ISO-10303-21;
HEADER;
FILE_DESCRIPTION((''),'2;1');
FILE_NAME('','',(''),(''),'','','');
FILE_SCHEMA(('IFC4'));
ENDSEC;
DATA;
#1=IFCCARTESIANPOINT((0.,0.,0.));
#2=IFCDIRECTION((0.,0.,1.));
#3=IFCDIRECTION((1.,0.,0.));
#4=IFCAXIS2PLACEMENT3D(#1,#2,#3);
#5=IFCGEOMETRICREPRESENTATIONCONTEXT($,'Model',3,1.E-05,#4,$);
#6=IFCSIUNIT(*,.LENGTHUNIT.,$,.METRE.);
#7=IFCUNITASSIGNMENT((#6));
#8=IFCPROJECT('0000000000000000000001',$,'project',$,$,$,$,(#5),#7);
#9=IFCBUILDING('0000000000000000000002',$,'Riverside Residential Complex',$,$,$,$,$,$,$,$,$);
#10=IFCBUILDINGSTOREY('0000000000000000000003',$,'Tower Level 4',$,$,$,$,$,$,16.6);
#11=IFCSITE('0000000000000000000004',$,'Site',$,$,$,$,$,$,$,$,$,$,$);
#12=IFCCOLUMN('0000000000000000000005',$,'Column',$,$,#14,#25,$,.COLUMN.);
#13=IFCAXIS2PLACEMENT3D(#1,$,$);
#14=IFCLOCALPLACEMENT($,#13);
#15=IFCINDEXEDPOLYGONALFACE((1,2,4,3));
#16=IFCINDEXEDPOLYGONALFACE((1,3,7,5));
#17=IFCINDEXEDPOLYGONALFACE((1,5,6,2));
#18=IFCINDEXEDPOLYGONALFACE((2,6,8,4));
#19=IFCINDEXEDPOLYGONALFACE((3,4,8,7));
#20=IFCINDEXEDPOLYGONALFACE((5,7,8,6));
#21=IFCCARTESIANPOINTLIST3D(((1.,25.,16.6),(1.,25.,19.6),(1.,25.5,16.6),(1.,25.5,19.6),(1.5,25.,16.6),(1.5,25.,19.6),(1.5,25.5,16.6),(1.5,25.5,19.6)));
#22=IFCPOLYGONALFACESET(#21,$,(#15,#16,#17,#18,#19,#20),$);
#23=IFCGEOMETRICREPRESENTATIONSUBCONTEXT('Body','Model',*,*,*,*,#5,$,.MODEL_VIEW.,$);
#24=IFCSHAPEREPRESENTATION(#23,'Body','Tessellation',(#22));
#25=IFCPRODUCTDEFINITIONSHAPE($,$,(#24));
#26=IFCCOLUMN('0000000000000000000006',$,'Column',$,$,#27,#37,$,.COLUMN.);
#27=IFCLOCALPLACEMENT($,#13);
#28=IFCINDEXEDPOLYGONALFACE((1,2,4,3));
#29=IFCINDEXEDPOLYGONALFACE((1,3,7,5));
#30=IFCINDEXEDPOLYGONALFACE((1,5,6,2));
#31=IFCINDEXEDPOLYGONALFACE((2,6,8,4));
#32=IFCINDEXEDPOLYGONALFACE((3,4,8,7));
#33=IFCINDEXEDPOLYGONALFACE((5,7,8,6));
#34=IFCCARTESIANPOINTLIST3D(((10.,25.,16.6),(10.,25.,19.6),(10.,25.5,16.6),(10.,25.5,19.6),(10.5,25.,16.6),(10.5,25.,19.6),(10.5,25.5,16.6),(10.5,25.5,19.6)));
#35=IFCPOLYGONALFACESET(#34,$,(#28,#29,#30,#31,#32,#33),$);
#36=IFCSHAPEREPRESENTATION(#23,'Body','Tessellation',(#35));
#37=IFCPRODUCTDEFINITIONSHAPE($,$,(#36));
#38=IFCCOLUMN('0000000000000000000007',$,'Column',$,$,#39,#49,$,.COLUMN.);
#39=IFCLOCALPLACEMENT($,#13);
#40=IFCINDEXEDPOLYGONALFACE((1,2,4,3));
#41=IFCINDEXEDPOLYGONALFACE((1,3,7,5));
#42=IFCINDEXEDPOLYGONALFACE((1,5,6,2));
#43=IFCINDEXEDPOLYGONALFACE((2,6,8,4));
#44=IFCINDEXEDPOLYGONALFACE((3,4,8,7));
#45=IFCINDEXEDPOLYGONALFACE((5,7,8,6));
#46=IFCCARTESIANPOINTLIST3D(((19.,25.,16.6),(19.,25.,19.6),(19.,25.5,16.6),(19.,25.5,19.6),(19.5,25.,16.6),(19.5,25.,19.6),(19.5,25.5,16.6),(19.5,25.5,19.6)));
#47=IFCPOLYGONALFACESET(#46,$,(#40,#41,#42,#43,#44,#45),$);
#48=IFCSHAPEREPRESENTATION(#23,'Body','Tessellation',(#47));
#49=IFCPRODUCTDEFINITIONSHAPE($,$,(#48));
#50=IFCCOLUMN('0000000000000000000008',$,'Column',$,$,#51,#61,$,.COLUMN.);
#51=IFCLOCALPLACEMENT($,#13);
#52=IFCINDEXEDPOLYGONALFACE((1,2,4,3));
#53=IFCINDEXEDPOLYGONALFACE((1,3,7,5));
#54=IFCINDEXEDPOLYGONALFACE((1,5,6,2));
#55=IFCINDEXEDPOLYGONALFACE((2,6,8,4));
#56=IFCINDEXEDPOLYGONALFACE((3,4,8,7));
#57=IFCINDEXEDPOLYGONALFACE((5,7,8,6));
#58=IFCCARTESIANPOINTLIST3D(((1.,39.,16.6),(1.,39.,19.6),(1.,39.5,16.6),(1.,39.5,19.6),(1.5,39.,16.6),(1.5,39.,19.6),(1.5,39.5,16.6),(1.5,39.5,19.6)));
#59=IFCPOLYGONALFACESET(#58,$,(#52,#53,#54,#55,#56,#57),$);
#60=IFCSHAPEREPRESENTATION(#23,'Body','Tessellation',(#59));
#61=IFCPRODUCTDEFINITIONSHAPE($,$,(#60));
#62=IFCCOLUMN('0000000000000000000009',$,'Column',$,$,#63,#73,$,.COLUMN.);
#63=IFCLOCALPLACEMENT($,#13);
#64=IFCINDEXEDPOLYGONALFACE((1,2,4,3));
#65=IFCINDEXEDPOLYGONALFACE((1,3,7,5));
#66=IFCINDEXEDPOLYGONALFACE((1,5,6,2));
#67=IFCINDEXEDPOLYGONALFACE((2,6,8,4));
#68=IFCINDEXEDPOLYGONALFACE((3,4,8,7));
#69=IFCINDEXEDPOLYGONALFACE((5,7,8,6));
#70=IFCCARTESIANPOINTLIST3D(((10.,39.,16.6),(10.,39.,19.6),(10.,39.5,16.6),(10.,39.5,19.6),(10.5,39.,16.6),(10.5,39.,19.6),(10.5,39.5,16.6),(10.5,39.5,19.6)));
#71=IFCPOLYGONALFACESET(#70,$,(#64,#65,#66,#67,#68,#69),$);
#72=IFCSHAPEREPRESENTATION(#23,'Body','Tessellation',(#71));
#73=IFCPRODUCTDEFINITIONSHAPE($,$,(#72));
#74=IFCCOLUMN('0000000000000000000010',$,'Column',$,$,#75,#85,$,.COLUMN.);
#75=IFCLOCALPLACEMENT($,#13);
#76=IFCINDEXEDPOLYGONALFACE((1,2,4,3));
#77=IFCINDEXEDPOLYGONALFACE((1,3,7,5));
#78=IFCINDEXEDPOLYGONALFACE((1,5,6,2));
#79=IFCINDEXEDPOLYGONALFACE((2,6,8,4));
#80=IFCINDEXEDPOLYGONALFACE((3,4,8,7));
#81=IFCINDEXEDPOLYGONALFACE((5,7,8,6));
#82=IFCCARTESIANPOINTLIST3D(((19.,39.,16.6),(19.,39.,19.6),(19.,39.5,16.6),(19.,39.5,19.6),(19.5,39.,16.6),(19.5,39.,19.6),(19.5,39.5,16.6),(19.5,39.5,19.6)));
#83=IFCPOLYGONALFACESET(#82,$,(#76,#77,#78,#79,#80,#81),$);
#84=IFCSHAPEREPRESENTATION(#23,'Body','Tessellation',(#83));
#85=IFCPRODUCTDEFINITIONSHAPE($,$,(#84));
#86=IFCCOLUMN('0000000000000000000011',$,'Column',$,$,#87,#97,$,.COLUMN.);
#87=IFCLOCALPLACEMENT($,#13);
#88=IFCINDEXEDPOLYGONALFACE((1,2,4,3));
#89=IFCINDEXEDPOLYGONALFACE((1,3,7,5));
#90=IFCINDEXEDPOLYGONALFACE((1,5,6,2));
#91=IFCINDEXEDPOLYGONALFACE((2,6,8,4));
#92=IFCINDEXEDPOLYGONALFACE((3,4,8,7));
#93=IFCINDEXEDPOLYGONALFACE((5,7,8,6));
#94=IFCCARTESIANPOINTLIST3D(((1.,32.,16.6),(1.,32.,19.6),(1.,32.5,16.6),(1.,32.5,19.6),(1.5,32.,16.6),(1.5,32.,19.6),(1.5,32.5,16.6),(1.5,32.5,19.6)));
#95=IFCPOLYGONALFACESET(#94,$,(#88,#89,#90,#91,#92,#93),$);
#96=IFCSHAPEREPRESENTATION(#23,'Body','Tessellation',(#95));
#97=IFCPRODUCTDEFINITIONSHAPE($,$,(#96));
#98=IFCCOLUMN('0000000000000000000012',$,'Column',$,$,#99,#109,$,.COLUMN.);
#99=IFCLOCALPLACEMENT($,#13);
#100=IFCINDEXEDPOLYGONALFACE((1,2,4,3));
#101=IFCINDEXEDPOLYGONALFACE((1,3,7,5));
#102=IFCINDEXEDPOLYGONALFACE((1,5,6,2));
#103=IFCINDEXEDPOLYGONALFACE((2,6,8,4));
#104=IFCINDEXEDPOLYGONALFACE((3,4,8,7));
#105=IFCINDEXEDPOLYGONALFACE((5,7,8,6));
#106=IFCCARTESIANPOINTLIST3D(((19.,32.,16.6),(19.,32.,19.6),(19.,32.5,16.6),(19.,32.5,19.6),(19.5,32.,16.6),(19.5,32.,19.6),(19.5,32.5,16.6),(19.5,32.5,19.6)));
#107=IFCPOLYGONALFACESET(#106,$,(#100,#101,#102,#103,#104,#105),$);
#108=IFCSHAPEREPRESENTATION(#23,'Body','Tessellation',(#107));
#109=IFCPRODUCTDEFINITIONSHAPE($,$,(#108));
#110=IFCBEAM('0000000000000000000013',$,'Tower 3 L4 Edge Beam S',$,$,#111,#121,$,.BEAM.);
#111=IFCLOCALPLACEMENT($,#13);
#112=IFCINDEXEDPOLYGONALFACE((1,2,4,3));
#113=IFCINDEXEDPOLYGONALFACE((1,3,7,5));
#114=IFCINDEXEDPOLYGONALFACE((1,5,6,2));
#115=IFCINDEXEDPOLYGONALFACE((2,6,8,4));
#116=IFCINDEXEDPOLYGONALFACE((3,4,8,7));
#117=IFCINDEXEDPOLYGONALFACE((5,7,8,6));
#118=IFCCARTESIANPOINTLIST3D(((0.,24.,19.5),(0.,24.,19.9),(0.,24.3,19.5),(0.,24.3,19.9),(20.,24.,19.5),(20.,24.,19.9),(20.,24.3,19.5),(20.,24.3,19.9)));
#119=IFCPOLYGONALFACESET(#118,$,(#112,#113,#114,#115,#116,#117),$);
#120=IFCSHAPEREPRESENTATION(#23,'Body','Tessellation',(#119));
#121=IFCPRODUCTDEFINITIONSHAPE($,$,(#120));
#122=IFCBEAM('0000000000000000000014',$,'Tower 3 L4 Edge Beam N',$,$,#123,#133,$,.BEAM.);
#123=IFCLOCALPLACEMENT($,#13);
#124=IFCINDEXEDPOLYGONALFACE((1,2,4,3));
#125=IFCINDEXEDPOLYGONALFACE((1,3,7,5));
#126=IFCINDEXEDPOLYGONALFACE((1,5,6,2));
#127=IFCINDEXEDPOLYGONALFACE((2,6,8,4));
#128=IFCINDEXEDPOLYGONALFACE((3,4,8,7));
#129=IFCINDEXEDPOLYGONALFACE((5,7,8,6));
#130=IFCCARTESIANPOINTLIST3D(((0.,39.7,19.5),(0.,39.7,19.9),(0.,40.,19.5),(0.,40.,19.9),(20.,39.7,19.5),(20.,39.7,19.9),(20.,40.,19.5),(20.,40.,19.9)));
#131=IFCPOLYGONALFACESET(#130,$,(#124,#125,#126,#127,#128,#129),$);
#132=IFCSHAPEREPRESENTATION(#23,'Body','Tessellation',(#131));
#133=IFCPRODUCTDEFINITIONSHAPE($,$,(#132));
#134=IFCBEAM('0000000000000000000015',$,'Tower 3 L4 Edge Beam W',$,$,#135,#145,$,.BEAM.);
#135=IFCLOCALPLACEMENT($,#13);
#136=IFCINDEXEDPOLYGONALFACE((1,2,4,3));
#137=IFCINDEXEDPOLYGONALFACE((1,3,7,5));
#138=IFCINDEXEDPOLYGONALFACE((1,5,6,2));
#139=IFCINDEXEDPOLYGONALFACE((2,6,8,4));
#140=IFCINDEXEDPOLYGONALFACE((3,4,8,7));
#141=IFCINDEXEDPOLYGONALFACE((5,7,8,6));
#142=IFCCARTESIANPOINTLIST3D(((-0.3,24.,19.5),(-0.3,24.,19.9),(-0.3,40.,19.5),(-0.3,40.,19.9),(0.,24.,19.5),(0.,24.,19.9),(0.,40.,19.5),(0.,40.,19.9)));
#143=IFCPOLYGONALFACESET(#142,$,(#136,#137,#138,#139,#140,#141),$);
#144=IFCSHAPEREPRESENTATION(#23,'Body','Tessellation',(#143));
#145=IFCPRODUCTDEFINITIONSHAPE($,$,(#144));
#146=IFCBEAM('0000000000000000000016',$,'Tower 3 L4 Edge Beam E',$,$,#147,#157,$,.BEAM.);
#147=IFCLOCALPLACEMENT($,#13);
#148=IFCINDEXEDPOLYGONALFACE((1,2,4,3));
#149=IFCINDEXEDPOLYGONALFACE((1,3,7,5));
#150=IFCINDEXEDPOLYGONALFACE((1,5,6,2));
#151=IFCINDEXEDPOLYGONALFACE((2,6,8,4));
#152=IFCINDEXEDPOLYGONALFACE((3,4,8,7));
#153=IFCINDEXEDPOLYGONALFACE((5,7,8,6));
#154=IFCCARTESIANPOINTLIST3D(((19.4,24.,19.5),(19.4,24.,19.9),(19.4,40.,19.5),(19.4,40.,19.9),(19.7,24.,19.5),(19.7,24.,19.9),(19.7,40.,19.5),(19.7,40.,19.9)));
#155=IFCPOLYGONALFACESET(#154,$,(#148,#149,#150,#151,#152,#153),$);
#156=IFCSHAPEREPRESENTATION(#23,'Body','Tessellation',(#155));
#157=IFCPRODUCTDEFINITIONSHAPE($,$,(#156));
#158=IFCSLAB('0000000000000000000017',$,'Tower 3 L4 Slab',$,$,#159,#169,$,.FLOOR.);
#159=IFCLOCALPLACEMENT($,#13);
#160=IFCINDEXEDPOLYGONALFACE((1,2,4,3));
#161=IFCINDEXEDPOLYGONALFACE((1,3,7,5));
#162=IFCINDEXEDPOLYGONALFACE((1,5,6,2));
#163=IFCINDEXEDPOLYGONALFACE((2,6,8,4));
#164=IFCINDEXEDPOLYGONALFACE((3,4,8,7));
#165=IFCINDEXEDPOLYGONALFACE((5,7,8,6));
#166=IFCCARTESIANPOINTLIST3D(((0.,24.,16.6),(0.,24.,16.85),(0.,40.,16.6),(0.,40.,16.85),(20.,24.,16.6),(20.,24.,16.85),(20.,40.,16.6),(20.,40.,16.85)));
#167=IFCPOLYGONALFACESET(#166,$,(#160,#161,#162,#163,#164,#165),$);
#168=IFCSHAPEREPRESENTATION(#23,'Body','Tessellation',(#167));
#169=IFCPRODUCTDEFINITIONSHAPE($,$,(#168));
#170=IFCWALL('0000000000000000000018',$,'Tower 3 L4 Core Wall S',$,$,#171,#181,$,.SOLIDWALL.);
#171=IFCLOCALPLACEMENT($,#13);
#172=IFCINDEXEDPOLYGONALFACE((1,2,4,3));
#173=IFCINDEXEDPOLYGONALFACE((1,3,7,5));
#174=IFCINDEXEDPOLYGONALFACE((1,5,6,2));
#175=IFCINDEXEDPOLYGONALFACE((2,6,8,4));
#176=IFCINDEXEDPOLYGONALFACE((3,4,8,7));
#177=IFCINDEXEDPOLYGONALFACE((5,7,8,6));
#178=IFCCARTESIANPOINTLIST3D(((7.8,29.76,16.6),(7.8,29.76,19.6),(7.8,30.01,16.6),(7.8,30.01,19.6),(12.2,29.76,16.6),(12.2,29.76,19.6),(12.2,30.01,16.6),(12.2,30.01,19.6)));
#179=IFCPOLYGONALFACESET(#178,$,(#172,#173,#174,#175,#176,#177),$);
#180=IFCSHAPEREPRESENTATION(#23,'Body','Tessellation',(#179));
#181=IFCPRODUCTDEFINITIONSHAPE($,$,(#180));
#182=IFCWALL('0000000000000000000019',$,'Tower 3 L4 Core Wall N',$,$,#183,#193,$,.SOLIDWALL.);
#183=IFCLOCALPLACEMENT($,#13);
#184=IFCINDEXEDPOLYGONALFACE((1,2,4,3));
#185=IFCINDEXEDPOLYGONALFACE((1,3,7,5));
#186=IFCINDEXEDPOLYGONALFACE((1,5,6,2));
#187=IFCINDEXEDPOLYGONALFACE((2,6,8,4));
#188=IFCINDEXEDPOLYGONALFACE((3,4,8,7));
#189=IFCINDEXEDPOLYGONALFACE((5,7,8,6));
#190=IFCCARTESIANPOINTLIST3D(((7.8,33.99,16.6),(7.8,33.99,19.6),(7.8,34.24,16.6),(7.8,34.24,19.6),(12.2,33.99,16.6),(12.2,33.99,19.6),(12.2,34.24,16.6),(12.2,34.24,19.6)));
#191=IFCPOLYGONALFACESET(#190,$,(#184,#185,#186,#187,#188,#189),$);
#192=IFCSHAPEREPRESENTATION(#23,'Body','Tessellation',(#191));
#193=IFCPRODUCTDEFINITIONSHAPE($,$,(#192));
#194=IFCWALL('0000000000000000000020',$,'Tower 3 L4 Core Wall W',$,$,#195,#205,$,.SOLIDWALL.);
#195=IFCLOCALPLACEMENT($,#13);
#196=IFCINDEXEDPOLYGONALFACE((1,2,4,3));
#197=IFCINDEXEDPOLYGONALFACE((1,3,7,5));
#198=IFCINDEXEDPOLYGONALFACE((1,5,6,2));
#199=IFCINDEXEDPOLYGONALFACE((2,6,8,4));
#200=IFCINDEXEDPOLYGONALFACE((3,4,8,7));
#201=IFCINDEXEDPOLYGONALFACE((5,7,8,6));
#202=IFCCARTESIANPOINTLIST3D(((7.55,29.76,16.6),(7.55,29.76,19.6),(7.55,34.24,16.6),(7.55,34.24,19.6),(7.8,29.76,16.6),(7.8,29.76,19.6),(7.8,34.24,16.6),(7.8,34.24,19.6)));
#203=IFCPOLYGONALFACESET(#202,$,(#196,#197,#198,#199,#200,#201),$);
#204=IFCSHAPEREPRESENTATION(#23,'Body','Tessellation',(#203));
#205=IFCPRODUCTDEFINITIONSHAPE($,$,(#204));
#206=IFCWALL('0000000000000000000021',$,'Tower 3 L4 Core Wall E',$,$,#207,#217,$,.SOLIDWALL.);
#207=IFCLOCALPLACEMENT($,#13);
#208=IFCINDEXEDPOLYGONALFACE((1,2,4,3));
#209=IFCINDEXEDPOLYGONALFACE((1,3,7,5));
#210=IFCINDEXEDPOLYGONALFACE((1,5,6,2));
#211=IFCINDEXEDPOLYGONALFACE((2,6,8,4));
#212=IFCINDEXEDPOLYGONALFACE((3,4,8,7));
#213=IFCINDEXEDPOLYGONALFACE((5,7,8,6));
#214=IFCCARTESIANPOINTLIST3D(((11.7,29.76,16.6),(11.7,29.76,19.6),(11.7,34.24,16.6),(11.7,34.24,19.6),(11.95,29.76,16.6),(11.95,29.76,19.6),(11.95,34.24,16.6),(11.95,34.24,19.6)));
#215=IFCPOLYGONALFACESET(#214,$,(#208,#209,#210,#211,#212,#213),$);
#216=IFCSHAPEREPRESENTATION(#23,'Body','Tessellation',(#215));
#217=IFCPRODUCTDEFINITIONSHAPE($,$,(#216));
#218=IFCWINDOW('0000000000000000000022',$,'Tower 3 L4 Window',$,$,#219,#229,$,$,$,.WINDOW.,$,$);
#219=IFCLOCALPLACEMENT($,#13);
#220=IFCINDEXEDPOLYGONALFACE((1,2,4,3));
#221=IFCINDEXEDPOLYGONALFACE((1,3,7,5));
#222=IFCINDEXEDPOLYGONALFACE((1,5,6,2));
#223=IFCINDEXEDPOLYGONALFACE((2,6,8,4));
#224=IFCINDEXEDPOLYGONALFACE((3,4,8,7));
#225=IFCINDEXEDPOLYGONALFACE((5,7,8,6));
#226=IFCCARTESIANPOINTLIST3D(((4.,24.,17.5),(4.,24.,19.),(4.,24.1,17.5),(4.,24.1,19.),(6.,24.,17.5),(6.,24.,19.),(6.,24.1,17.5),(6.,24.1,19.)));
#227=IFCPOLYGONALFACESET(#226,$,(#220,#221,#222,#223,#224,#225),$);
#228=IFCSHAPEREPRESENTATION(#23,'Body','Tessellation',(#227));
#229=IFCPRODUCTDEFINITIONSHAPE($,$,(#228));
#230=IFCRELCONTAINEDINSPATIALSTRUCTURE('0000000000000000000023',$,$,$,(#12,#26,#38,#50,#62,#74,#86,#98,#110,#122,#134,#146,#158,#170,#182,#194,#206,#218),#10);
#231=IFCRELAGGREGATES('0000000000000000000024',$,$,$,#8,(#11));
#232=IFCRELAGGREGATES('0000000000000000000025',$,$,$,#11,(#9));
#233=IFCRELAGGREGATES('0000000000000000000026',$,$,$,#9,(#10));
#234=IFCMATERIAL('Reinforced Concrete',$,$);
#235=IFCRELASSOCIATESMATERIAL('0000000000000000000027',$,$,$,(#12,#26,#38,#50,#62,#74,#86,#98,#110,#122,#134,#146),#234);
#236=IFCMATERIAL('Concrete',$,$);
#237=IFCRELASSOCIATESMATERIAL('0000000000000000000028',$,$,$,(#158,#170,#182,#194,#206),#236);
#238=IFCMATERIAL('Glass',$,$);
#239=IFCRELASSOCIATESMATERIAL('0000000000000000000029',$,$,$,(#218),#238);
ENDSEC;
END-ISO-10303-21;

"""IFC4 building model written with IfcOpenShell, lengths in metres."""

from ifc_helpers import new_model, si_unit, frame, origin_with_axes, place, context, subcontext, project, spatial, line, indexed_curve, outline, extrude, material, element, save


model = new_model("IFC4")

# Units and contexts
model_context = context("Model", 3, precision=1e-05, world=origin_with_axes())
body_context = subcontext(model_context, "Body", "Model", "MODEL_VIEW")
ifc_project = project(units=[si_unit("LENGTHUNIT", "METRE")], contexts=[model_context])

# Site, building, storey
site = spatial("IfcSite", under=ifc_project, Name="Site")
building = spatial("IfcBuilding", under=site, Name="Riverside Residential Complex")
storey = spatial("IfcBuildingStorey", under=building, Name="Tower Level 4", Elevation=16.6)

# Columns
ifc_material_1 = material(Name="Reinforced Concrete")
for number, where, z_axis, x_axis, name in (
    (1, (1.0, 25.0, 16.6), (0.0, 0.0, 1.0), (1.0, 0.0, 0.0), "Column"),
    (2, (10.0, 25.0, 16.6), (0.0, 0.0, 1.0), (1.0, 0.0, 0.0), "Column"),
    (3, (19.0, 25.0, 16.6), (0.0, 0.0, 1.0), (1.0, 0.0, 0.0), "Column"),
    (4, (1.0, 39.0, 16.6), (0.0, 0.0, 1.0), (1.0, 0.0, 0.0), "Column"),
    (5, (10.0, 39.0, 16.6), (0.0, 0.0, 1.0), (1.0, 0.0, 0.0), "Column"),
    (6, (19.0, 39.0, 16.6), (0.0, 0.0, 1.0), (1.0, 0.0, 0.0), "Column"),
    (7, (1.0, 32.0, 16.6), (0.0, 0.0, 1.0), (1.0, 0.0, 0.0), "Column"),
    (8, (19.0, 32.0, 16.6), (0.0, 0.0, 1.0), (1.0, 0.0, 0.0), "Column"),
):
    element("IfcColumn", number, at=place(None, frame(where, z_axis=z_axis, x_axis=x_axis)), inside=storey, material=ifc_material_1, Name=name, PredefinedType="COLUMN", context=body_context, shape_type="SweptSolid", body=[
        extrude(outline(indexed_curve([(0.0, 0.0), (0.5, 0.0), (0.5, 0.5), (0.0, 0.5)], segments=[line(1, 2, 3, 4, 1)])), origin_with_axes(), (0.0, 0.0, 1.0), 3.0),
    ])

# Beams
for number, where, z_axis, x_axis, name in (
    (9, (0.0, 24.0, 19.5), (0.0, 0.0, 1.0), (1.0, 0.0, 0.0), "Tower 3 L4 Edge Beam S"),
    (10, (0.0, 39.7, 19.5), (0.0, 0.0, 1.0), (1.0, 0.0, 0.0), "Tower 3 L4 Edge Beam N"),
):
    element("IfcBeam", number, at=place(None, frame(where, z_axis=z_axis, x_axis=x_axis)), inside=storey, material=ifc_material_1, Name=name, PredefinedType="BEAM", context=body_context, shape_type="SweptSolid", body=[
        extrude(outline(indexed_curve([(0.0, 0.0), (20.0, 0.0), (20.0, 0.3), (0.0, 0.3)], segments=[line(1, 2, 3, 4, 1)])), origin_with_axes(), (0.0, 0.0, 1.0), 0.4),
    ])
for number, where, z_axis, x_axis, name in (
    (11, (0.0, 24.0, 19.5), (0.0, 0.0, 1.0), (0.0, 1.0, 0.0), "Tower 3 L4 Edge Beam W"),
    (12, (19.7, 24.0, 19.5), (0.0, 0.0, 1.0), (0.0, 1.0, 0.0), "Tower 3 L4 Edge Beam E"),
):
    element("IfcBeam", number, at=place(None, frame(where, z_axis=z_axis, x_axis=x_axis)), inside=storey, material=ifc_material_1, Name=name, PredefinedType="BEAM", context=body_context, shape_type="SweptSolid", body=[
        extrude(outline(indexed_curve([(0.0, 0.0), (16.0, 0.0), (16.0, 0.3), (0.0, 0.3)], segments=[line(1, 2, 3, 4, 1)])), origin_with_axes(), (0.0, 0.0, 1.0), 0.4),
    ])

# Slab
ifc_material_2 = material(Name="Concrete")
slab_placement = place(None, frame((0.0, 24.0, 16.6), z_axis=(0.0, 0.0, 1.0), x_axis=(1.0, 0.0, 0.0)))
element("IfcSlab", 13, at=slab_placement, inside=storey, material=ifc_material_2, Name="Tower 3 L4 Slab", PredefinedType="FLOOR", context=body_context, shape_type="SweptSolid", body=[
    extrude(outline(indexed_curve([(0.0, 0.0), (20.0, 0.0), (20.0, 16.0), (0.0, 16.0)], segments=[line(1, 2, 3, 4, 1)])), origin_with_axes(), (0.0, 0.0, 1.0), 0.25),
])

# Walls
for number, where, z_axis, x_axis, name in (
    (14, (7.8, 29.76, 16.6), (0.0, 0.0, 1.0), (1.0, 0.0, 0.0), "Tower 3 L4 Core Wall S"),
    (15, (7.8, 33.99, 16.6), (0.0, 0.0, 1.0), (1.0, 0.0, 0.0), "Tower 3 L4 Core Wall N"),
):
    element("IfcWall", number, at=place(None, frame(where, z_axis=z_axis, x_axis=x_axis)), inside=storey, material=ifc_material_2, Name=name, PredefinedType="SOLIDWALL", context=body_context, shape_type="SweptSolid", body=[
        extrude(outline(indexed_curve([(0.0, 0.0), (4.4, 0.0), (4.4, 0.25), (0.0, 0.25)], segments=[line(1, 2, 3, 4, 1)])), origin_with_axes(), (0.0, 0.0, 1.0), 3.0),
    ])
for number, where, z_axis, x_axis, name in (
    (16, (7.8, 29.76, 16.6), (0.0, 0.0, 1.0), (0.0, 1.0, 0.0), "Tower 3 L4 Core Wall W"),
    (17, (11.95, 29.76, 16.6), (0.0, 0.0, 1.0), (0.0, 1.0, 0.0), "Tower 3 L4 Core Wall E"),
):
    element("IfcWall", number, at=place(None, frame(where, z_axis=z_axis, x_axis=x_axis)), inside=storey, material=ifc_material_2, Name=name, PredefinedType="SOLIDWALL", context=body_context, shape_type="SweptSolid", body=[
        extrude(outline(indexed_curve([(0.0, 0.0), (4.48, 0.0), (4.48, 0.25), (0.0, 0.25)], segments=[line(1, 2, 3, 4, 1)])), origin_with_axes(), (0.0, 0.0, 1.0), 3.0),
    ])

# Window
ifc_material_3 = material(Name="Glass")
for number, where, z_axis, x_axis, name in (
    (18, (4.0, 24.0, 17.5), (0.0, 0.0, 1.0), (1.0, 0.0, 0.0), "Tower 3 L4 Window"),
):
    element("IfcWindow", number, at=place(None, frame(where, z_axis=z_axis, x_axis=x_axis)), inside=storey, material=ifc_material_3, Name=name, PredefinedType="WINDOW", context=body_context, shape_type="SweptSolid", body=[
        extrude(outline(indexed_curve([(0.0, 0.0), (2.0, 0.0), (2.0, 0.1), (0.0, 0.1)], segments=[line(1, 2, 3, 4, 1)])), origin_with_axes(), (0.0, 0.0, 1.0), 1.5),
    ])

save(model, "model.ifc")
